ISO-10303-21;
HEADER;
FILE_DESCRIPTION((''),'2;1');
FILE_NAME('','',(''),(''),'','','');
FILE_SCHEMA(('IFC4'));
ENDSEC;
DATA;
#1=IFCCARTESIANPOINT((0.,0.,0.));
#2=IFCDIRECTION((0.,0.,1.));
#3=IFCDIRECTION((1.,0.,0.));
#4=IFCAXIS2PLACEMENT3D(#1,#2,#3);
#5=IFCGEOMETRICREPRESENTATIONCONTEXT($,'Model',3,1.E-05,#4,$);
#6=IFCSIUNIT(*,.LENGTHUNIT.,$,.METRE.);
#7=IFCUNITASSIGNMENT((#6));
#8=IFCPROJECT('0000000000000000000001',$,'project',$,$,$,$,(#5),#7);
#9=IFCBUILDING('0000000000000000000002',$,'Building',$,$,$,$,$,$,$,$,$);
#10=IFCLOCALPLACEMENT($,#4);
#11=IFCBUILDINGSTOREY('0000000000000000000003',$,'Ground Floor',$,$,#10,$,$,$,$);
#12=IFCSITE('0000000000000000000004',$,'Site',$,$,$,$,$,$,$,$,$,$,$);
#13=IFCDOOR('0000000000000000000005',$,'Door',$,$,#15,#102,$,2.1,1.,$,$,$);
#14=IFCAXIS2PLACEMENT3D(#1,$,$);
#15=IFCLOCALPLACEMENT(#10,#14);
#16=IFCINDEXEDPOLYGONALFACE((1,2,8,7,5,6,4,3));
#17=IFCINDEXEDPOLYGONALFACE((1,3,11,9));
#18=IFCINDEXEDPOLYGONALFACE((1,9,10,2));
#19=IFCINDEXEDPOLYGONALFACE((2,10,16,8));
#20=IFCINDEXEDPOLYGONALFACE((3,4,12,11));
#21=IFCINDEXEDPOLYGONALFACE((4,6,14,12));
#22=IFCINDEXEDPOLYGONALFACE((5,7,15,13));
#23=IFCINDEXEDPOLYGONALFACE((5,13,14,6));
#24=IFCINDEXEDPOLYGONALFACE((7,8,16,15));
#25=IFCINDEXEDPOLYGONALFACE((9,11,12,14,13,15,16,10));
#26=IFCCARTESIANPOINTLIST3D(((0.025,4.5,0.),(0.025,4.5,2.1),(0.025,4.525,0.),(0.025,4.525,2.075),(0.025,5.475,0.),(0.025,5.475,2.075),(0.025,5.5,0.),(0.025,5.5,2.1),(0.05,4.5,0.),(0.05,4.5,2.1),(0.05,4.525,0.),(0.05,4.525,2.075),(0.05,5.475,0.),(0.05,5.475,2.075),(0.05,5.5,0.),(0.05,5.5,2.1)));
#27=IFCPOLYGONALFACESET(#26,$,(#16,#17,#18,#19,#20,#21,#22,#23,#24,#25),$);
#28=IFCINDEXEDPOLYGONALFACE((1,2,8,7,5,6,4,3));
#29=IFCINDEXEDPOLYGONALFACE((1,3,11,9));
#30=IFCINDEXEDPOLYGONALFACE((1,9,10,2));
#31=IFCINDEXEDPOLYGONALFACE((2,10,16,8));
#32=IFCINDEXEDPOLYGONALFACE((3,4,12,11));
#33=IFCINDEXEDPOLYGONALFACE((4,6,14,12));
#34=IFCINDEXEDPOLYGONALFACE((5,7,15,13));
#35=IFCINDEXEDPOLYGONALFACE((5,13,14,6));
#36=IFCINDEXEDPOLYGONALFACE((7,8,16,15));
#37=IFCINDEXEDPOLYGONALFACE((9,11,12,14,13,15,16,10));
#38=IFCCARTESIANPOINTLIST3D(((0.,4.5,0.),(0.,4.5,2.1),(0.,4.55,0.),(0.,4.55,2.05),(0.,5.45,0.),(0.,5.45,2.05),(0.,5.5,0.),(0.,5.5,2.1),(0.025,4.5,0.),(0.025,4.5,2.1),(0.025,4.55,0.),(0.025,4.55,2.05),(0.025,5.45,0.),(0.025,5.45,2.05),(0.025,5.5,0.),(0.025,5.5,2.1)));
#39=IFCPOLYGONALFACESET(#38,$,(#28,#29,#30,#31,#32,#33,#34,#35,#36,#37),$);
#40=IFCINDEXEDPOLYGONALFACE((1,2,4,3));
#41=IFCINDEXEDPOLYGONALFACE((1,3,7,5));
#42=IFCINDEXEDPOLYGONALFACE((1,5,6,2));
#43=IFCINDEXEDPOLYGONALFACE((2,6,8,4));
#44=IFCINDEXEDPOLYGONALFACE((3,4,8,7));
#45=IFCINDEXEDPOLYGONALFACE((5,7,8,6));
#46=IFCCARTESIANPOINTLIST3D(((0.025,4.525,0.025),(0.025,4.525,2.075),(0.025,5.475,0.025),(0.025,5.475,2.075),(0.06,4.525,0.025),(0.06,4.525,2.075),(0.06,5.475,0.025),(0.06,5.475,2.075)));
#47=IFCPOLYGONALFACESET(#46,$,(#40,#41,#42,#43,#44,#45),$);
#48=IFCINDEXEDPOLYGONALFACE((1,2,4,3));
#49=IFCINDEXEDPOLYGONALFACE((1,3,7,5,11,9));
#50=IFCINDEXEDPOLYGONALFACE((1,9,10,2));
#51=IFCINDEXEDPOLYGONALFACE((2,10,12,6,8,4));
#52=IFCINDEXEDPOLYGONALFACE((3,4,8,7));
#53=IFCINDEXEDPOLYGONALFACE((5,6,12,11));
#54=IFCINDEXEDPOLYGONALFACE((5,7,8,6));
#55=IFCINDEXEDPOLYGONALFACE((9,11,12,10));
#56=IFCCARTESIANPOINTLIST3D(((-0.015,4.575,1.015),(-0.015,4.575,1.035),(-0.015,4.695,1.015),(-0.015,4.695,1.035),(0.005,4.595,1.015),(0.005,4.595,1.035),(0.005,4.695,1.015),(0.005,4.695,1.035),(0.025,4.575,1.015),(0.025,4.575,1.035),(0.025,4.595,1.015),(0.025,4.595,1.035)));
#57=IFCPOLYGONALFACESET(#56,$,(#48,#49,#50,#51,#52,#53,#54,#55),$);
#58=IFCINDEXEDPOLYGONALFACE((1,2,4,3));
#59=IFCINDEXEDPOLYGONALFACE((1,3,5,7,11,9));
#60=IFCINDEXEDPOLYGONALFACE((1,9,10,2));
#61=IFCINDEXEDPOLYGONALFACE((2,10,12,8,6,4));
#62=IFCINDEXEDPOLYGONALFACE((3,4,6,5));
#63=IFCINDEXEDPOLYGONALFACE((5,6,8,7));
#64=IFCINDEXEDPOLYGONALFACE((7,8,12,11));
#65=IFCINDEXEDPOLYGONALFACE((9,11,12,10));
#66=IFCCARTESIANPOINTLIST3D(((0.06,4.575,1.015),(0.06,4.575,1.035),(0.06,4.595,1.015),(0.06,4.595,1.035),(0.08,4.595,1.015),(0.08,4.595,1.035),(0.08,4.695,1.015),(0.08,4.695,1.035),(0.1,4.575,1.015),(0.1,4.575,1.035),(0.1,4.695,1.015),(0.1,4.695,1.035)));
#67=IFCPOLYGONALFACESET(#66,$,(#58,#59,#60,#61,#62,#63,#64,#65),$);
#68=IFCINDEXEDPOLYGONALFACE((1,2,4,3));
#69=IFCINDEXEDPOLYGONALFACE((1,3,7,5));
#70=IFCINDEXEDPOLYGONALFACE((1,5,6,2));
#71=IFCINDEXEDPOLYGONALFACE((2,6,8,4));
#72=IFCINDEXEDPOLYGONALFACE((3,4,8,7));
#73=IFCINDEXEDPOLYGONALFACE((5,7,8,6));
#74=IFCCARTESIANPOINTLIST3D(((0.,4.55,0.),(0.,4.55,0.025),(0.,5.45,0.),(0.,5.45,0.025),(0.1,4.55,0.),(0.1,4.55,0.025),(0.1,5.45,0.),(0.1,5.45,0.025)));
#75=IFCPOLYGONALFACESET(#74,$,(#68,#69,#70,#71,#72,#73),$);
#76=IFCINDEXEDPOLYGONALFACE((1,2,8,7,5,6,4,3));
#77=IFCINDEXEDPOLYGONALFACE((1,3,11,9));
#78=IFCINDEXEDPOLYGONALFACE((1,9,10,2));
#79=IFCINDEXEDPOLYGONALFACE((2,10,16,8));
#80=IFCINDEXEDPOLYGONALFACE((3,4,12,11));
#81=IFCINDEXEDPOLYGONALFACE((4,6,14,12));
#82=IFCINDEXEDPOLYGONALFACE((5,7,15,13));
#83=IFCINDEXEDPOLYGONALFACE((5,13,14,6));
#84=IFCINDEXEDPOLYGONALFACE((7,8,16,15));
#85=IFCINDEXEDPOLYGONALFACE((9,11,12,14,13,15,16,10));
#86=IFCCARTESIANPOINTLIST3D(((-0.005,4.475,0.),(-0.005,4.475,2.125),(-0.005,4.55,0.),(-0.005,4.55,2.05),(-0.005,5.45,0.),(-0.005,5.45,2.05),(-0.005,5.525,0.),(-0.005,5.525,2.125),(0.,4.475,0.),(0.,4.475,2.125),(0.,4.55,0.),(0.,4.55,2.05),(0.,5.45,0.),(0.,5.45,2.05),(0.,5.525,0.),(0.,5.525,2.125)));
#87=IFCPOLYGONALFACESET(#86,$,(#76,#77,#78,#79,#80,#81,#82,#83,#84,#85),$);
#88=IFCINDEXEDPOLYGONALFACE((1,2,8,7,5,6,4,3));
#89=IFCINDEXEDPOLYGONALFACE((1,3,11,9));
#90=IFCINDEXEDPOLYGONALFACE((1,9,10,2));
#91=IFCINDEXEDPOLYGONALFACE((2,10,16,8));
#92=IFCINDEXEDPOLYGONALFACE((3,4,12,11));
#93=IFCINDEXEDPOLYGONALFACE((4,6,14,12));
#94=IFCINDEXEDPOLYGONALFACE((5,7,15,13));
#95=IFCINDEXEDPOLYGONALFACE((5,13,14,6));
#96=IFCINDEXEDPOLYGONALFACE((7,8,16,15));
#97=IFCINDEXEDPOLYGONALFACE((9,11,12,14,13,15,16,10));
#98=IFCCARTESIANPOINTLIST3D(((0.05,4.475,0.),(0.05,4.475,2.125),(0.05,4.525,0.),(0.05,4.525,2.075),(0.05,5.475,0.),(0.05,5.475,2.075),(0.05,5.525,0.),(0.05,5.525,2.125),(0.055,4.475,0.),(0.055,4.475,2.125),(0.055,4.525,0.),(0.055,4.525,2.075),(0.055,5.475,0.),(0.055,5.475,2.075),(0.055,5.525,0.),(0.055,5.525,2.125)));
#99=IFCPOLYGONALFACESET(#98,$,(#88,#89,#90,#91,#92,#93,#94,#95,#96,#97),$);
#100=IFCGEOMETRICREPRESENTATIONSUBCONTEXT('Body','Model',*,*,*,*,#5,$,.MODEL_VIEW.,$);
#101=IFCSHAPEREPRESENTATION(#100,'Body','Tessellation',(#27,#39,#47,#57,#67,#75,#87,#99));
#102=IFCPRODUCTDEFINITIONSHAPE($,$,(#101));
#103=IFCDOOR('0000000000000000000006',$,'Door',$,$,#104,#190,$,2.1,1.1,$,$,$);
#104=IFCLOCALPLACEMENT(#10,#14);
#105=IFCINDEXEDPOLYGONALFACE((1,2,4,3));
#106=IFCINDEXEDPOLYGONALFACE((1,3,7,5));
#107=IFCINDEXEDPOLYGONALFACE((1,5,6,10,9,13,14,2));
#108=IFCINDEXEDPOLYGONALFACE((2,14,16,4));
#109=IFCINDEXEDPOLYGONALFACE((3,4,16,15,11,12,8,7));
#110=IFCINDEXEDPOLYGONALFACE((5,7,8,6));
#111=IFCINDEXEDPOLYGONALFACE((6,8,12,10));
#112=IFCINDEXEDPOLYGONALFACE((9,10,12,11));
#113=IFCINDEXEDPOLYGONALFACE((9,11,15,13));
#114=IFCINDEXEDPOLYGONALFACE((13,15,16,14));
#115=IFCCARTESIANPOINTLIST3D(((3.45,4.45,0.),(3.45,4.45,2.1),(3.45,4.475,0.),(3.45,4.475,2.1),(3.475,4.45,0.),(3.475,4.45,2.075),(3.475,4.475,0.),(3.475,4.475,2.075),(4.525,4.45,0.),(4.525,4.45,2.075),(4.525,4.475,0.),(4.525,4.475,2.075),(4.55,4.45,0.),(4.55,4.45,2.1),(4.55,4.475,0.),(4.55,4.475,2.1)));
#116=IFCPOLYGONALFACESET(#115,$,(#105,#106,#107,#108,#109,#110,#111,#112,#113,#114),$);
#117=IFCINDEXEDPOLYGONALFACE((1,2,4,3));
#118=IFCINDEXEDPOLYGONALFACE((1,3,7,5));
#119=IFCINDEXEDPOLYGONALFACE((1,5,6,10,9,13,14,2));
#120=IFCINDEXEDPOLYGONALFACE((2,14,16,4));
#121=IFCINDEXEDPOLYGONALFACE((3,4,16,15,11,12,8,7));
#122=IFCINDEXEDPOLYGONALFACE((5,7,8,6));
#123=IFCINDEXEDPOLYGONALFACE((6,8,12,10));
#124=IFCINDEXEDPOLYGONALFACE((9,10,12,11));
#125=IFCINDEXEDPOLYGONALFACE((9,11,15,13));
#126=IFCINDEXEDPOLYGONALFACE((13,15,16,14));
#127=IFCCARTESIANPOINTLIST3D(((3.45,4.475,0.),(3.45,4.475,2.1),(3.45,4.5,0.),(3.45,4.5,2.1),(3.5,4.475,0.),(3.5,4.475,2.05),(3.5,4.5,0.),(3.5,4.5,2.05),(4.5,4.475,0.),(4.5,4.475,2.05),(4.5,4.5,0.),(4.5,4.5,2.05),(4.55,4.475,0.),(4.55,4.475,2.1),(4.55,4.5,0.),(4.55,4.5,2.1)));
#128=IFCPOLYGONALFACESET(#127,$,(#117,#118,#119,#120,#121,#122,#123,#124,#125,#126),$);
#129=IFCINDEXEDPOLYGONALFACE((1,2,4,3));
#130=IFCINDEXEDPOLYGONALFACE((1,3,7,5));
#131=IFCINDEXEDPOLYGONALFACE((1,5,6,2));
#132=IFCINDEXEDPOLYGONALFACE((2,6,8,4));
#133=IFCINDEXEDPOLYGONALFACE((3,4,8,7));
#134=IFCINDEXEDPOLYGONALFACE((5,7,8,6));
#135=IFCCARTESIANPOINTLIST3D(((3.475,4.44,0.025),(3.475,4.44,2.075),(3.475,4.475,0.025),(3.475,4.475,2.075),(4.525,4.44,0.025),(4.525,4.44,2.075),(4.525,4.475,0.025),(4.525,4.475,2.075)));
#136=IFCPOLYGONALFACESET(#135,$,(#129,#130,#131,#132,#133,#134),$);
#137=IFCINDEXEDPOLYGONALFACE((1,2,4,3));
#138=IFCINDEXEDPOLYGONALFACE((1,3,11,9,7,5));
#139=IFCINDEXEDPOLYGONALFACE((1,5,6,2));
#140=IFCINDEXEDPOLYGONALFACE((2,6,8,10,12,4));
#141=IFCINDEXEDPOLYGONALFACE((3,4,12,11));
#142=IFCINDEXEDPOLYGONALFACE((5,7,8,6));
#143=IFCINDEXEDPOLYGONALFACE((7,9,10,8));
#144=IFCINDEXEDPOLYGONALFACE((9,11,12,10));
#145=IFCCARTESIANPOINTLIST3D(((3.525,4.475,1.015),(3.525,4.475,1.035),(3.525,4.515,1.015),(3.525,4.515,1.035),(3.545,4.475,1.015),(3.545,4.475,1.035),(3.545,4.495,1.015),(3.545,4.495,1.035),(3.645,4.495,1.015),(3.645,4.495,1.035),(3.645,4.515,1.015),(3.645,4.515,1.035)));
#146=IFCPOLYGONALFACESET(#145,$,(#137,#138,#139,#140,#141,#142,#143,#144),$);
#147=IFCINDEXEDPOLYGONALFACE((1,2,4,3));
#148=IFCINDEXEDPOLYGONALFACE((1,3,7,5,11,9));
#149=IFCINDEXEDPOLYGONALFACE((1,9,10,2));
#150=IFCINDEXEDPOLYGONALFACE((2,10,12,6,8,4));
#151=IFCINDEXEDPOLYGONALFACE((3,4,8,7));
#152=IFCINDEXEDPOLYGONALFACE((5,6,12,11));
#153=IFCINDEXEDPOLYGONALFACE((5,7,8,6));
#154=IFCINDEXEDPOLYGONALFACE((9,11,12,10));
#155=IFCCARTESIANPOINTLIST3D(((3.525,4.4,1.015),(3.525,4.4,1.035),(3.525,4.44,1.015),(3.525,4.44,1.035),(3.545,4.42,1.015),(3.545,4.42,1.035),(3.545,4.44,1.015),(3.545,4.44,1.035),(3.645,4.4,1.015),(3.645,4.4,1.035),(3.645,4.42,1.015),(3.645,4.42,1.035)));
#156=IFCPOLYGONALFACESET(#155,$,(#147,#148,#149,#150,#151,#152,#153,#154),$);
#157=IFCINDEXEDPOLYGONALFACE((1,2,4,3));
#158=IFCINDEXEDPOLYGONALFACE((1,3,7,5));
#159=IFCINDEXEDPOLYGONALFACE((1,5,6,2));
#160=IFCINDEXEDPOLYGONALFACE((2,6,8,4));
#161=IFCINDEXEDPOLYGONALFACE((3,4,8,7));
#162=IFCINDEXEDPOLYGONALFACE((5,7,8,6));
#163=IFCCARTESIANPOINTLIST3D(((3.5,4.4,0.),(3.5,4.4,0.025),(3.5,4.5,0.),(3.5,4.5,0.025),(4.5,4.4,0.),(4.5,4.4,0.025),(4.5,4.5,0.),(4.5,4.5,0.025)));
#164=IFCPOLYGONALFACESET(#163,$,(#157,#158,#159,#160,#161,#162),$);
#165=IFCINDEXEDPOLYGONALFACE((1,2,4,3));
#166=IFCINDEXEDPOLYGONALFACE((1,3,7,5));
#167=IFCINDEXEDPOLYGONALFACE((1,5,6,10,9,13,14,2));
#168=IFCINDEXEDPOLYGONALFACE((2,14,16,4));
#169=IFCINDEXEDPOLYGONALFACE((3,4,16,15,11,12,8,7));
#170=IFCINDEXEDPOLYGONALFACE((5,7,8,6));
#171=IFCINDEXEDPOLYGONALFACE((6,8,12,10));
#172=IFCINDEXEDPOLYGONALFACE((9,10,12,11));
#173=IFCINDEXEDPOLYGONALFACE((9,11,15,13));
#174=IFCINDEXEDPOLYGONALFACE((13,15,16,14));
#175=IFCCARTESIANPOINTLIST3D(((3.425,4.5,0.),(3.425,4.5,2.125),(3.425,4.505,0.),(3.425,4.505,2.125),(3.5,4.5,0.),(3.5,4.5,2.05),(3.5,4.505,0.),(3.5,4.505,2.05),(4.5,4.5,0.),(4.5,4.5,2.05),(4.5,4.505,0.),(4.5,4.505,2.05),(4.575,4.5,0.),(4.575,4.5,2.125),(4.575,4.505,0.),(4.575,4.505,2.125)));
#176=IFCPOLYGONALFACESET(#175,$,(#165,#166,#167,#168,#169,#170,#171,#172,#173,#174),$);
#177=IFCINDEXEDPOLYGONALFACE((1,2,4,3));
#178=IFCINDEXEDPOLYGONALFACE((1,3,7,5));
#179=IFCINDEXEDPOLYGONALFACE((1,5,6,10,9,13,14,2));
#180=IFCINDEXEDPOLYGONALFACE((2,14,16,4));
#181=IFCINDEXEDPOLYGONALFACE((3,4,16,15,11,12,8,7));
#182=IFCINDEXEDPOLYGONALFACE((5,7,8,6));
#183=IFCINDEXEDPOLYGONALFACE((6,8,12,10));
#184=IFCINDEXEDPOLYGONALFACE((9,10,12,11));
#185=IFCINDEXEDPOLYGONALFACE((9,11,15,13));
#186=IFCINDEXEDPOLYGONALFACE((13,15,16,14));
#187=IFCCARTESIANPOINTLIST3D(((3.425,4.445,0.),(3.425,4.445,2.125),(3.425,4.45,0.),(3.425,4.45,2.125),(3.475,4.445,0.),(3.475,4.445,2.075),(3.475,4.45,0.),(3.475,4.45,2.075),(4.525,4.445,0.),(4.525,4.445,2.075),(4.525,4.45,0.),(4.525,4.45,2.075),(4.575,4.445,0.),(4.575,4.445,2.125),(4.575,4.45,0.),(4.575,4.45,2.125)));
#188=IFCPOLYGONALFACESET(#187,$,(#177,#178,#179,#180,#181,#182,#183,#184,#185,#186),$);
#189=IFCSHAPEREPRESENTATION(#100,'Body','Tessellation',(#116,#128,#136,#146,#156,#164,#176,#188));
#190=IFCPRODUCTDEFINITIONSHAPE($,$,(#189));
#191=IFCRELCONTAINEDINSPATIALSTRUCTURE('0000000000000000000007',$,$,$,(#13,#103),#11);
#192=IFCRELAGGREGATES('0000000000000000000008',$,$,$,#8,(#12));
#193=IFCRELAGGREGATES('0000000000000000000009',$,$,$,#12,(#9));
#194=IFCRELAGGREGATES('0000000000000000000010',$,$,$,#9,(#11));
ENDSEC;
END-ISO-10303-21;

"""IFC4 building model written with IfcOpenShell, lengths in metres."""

from ifc_helpers import new_model, si_unit, frame, origin_with_axes, place, context, subcontext, project, spatial, line, indexed_curve, outline, extrude, element, save


model = new_model("IFC4")

# Units and contexts
model_context = context("Model", 3, precision=1e-05, world=origin_with_axes())
body_context = subcontext(model_context, "Body", "Model", "MODEL_VIEW")
ifc_project = project(units=[si_unit("LENGTHUNIT", "METRE")], contexts=[model_context])

# Site, building, storey
site = spatial("IfcSite", under=ifc_project, Name="Site")
building = spatial("IfcBuilding", under=site, Name="Building")
storey_placement = place(None, origin_with_axes())
storey = spatial("IfcBuildingStorey", under=building, at=storey_placement, Name="Ground Floor")

# Doors
door_1_placement = place(storey_placement, frame((0.0, 5.5, 0.0), z_axis=(0.0, 0.0, 1.0), x_axis=(0.0, -1.0, 0.0)))
element("IfcDoor", 1, at=door_1_placement, inside=storey, Name="Door", OverallHeight=2.1, OverallWidth=1.0, context=body_context, shape_type="SweptSolid", body=[
    extrude(outline(indexed_curve([(0.0, 0.0), (0.0, 2.1), (1.0, 2.1), (1.0, 0.0), (0.975, 0.0), (0.975, 2.075), (0.025, 2.075), (0.025, 0.0)], segments=[line(1, 2, 3, 4, 5, 6, 7, 8, 1)])), frame((0.0, 0.025, 0.0), z_axis=(0.0, -1.0, 0.0), x_axis=(1.0, 0.0, 0.0)), (0.0, 0.0, -1.0), 0.025),
    extrude(outline(indexed_curve([(0.0, 0.0), (0.0, 2.1), (1.0, 2.1), (1.0, 0.0), (0.95, 0.0), (0.95, 2.05), (0.05, 2.05), (0.05, 0.0)], segments=[line(1, 2, 3, 4, 5, 6, 7, 8, 1)])), frame((0.0, 0.0, 0.0), z_axis=(0.0, -1.0, 0.0), x_axis=(1.0, 0.0, 0.0)), (0.0, 0.0, -1.0), 0.025),
    extrude(outline(indexed_curve([(0.0, 0.0), (0.95, 0.0), (0.95, 0.035), (0.0, 0.035)], segments=[line(1, 2, 3, 4, 1)])), frame((0.025, 0.025, 0.025), z_axis=(0.0, 0.0, 1.0), x_axis=(1.0, 0.0, 0.0)), (0.0, 0.0, 1.0), 2.05),
    extrude(outline(indexed_curve([(0.0, 0.0), (0.0, -0.04), (-0.12, -0.04), (-0.12, -0.02), (-0.02, -0.02), (-0.02, 0.0)], segments=[line(1, 2, 3, 4, 5, 6, 1)])), frame((0.925, 0.025, 1.015), z_axis=(0.0, 0.0, 1.0), x_axis=(1.0, 0.0, 0.0)), (0.0, 0.0, 1.0), 0.02),
    extrude(outline(indexed_curve([(0.0, 0.0), (0.0, 0.04), (-0.12, 0.04), (-0.12, 0.02), (-0.02, 0.02), (-0.02, 0.0)], segments=[line(1, 2, 3, 4, 5, 6, 1)])), frame((0.925, 0.06, 1.015), z_axis=(0.0, 0.0, 1.0), x_axis=(1.0, 0.0, 0.0)), (0.0, 0.0, 1.0), 0.02),
    extrude(outline(indexed_curve([(0.0, 0.0), (0.9, 0.0), (0.9, 0.1), (0.0, 0.1)], segments=[line(1, 2, 3, 4, 1)])), frame((0.05, 0.0, 0.0), z_axis=(0.0, 0.0, 1.0), x_axis=(1.0, 0.0, 0.0)), (0.0, 0.0, 1.0), 0.025),
    extrude(outline(indexed_curve([(0.0, 0.0), (0.0, 2.125), (1.05, 2.125), (1.05, 0.0), (0.975, 0.0), (0.975, 2.05), (0.075, 2.05), (0.075, 0.0)], segments=[line(1, 2, 3, 4, 5, 6, 7, 8, 1)])), frame((-0.025, -0.005, 0.0), z_axis=(0.0, -1.0, 0.0), x_axis=(1.0, 0.0, 0.0)), (0.0, 0.0, -1.0), 0.005),
    extrude(outline(indexed_curve([(0.0, 0.0), (0.0, 2.125), (1.05, 2.125), (1.05, 0.0), (1.0, 0.0), (1.0, 2.075), (0.05, 2.075), (0.05, 0.0)], segments=[line(1, 2, 3, 4, 5, 6, 7, 8, 1)])), frame((-0.025, 0.05, 0.0), z_axis=(0.0, -1.0, 0.0), x_axis=(1.0, 0.0, 0.0)), (0.0, 0.0, -1.0), 0.005),
])
door_2_placement = place(storey_placement, frame((4.55, 4.5, 0.0), z_axis=(0.0, 0.0, 1.0), x_axis=(-1.0, 0.0, 0.0)))
element("IfcDoor", 2, at=door_2_placement, inside=storey, Name="Door", OverallHeight=2.1, OverallWidth=1.1, context=body_context, shape_type="SweptSolid", body=[
    extrude(outline(indexed_curve([(0.0, 0.0), (0.0, 2.1), (1.1, 2.1), (1.1, 0.0), (1.075, 0.0), (1.075, 2.075), (0.025, 2.075), (0.025, 0.0)], segments=[line(1, 2, 3, 4, 5, 6, 7, 8, 1)])), frame((0.0, 0.025, 0.0), z_axis=(0.0, -1.0, 0.0), x_axis=(1.0, 0.0, 0.0)), (0.0, 0.0, -1.0), 0.025),
    extrude(outline(indexed_curve([(0.0, 0.0), (0.0, 2.1), (1.1, 2.1), (1.1, 0.0), (1.05, 0.0), (1.05, 2.05), (0.05, 2.05), (0.05, 0.0)], segments=[line(1, 2, 3, 4, 5, 6, 7, 8, 1)])), frame((0.0, 0.0, 0.0), z_axis=(0.0, -1.0, 0.0), x_axis=(1.0, 0.0, 0.0)), (0.0, 0.0, -1.0), 0.025),
    extrude(outline(indexed_curve([(0.0, 0.0), (1.05, 0.0), (1.05, 0.035), (0.0, 0.035)], segments=[line(1, 2, 3, 4, 1)])), frame((0.025, 0.025, 0.025), z_axis=(0.0, 0.0, 1.0), x_axis=(1.0, 0.0, 0.0)), (0.0, 0.0, 1.0), 2.05),
    extrude(outline(indexed_curve([(0.0, 0.0), (0.0, -0.04), (-0.12, -0.04), (-0.12, -0.02), (-0.02, -0.02), (-0.02, 0.0)], segments=[line(1, 2, 3, 4, 5, 6, 1)])), frame((1.025, 0.025, 1.015), z_axis=(0.0, 0.0, 1.0), x_axis=(1.0, 0.0, 0.0)), (0.0, 0.0, 1.0), 0.02),
    extrude(outline(indexed_curve([(0.0, 0.0), (0.0, 0.04), (-0.12, 0.04), (-0.12, 0.02), (-0.02, 0.02), (-0.02, 0.0)], segments=[line(1, 2, 3, 4, 5, 6, 1)])), frame((1.025, 0.06, 1.015), z_axis=(0.0, 0.0, 1.0), x_axis=(1.0, 0.0, 0.0)), (0.0, 0.0, 1.0), 0.02),
    extrude(outline(indexed_curve([(0.0, 0.0), (1.0, 0.0), (1.0, 0.1), (0.0, 0.1)], segments=[line(1, 2, 3, 4, 1)])), frame((0.05, 0.0, 0.0), z_axis=(0.0, 0.0, 1.0), x_axis=(1.0, 0.0, 0.0)), (0.0, 0.0, 1.0), 0.025),
    extrude(outline(indexed_curve([(0.0, 0.0), (0.0, 2.125), (1.15, 2.125), (1.15, 0.0), (1.075, 0.0), (1.075, 2.05), (0.075, 2.05), (0.075, 0.0)], segments=[line(1, 2, 3, 4, 5, 6, 7, 8, 1)])), frame((-0.025, -0.005, 0.0), z_axis=(0.0, -1.0, 0.0), x_axis=(1.0, 0.0, 0.0)), (0.0, 0.0, -1.0), 0.005),
    extrude(outline(indexed_curve([(0.0, 0.0), (0.0, 2.125), (1.15, 2.125), (1.15, 0.0), (1.1, 0.0), (1.1, 2.075), (0.05, 2.075), (0.05, 0.0)], segments=[line(1, 2, 3, 4, 5, 6, 7, 8, 1)])), frame((-0.025, 0.05, 0.0), z_axis=(0.0, -1.0, 0.0), x_axis=(1.0, 0.0, 0.0)), (0.0, 0.0, -1.0), 0.005),
])

save(model, "model.ifc")
